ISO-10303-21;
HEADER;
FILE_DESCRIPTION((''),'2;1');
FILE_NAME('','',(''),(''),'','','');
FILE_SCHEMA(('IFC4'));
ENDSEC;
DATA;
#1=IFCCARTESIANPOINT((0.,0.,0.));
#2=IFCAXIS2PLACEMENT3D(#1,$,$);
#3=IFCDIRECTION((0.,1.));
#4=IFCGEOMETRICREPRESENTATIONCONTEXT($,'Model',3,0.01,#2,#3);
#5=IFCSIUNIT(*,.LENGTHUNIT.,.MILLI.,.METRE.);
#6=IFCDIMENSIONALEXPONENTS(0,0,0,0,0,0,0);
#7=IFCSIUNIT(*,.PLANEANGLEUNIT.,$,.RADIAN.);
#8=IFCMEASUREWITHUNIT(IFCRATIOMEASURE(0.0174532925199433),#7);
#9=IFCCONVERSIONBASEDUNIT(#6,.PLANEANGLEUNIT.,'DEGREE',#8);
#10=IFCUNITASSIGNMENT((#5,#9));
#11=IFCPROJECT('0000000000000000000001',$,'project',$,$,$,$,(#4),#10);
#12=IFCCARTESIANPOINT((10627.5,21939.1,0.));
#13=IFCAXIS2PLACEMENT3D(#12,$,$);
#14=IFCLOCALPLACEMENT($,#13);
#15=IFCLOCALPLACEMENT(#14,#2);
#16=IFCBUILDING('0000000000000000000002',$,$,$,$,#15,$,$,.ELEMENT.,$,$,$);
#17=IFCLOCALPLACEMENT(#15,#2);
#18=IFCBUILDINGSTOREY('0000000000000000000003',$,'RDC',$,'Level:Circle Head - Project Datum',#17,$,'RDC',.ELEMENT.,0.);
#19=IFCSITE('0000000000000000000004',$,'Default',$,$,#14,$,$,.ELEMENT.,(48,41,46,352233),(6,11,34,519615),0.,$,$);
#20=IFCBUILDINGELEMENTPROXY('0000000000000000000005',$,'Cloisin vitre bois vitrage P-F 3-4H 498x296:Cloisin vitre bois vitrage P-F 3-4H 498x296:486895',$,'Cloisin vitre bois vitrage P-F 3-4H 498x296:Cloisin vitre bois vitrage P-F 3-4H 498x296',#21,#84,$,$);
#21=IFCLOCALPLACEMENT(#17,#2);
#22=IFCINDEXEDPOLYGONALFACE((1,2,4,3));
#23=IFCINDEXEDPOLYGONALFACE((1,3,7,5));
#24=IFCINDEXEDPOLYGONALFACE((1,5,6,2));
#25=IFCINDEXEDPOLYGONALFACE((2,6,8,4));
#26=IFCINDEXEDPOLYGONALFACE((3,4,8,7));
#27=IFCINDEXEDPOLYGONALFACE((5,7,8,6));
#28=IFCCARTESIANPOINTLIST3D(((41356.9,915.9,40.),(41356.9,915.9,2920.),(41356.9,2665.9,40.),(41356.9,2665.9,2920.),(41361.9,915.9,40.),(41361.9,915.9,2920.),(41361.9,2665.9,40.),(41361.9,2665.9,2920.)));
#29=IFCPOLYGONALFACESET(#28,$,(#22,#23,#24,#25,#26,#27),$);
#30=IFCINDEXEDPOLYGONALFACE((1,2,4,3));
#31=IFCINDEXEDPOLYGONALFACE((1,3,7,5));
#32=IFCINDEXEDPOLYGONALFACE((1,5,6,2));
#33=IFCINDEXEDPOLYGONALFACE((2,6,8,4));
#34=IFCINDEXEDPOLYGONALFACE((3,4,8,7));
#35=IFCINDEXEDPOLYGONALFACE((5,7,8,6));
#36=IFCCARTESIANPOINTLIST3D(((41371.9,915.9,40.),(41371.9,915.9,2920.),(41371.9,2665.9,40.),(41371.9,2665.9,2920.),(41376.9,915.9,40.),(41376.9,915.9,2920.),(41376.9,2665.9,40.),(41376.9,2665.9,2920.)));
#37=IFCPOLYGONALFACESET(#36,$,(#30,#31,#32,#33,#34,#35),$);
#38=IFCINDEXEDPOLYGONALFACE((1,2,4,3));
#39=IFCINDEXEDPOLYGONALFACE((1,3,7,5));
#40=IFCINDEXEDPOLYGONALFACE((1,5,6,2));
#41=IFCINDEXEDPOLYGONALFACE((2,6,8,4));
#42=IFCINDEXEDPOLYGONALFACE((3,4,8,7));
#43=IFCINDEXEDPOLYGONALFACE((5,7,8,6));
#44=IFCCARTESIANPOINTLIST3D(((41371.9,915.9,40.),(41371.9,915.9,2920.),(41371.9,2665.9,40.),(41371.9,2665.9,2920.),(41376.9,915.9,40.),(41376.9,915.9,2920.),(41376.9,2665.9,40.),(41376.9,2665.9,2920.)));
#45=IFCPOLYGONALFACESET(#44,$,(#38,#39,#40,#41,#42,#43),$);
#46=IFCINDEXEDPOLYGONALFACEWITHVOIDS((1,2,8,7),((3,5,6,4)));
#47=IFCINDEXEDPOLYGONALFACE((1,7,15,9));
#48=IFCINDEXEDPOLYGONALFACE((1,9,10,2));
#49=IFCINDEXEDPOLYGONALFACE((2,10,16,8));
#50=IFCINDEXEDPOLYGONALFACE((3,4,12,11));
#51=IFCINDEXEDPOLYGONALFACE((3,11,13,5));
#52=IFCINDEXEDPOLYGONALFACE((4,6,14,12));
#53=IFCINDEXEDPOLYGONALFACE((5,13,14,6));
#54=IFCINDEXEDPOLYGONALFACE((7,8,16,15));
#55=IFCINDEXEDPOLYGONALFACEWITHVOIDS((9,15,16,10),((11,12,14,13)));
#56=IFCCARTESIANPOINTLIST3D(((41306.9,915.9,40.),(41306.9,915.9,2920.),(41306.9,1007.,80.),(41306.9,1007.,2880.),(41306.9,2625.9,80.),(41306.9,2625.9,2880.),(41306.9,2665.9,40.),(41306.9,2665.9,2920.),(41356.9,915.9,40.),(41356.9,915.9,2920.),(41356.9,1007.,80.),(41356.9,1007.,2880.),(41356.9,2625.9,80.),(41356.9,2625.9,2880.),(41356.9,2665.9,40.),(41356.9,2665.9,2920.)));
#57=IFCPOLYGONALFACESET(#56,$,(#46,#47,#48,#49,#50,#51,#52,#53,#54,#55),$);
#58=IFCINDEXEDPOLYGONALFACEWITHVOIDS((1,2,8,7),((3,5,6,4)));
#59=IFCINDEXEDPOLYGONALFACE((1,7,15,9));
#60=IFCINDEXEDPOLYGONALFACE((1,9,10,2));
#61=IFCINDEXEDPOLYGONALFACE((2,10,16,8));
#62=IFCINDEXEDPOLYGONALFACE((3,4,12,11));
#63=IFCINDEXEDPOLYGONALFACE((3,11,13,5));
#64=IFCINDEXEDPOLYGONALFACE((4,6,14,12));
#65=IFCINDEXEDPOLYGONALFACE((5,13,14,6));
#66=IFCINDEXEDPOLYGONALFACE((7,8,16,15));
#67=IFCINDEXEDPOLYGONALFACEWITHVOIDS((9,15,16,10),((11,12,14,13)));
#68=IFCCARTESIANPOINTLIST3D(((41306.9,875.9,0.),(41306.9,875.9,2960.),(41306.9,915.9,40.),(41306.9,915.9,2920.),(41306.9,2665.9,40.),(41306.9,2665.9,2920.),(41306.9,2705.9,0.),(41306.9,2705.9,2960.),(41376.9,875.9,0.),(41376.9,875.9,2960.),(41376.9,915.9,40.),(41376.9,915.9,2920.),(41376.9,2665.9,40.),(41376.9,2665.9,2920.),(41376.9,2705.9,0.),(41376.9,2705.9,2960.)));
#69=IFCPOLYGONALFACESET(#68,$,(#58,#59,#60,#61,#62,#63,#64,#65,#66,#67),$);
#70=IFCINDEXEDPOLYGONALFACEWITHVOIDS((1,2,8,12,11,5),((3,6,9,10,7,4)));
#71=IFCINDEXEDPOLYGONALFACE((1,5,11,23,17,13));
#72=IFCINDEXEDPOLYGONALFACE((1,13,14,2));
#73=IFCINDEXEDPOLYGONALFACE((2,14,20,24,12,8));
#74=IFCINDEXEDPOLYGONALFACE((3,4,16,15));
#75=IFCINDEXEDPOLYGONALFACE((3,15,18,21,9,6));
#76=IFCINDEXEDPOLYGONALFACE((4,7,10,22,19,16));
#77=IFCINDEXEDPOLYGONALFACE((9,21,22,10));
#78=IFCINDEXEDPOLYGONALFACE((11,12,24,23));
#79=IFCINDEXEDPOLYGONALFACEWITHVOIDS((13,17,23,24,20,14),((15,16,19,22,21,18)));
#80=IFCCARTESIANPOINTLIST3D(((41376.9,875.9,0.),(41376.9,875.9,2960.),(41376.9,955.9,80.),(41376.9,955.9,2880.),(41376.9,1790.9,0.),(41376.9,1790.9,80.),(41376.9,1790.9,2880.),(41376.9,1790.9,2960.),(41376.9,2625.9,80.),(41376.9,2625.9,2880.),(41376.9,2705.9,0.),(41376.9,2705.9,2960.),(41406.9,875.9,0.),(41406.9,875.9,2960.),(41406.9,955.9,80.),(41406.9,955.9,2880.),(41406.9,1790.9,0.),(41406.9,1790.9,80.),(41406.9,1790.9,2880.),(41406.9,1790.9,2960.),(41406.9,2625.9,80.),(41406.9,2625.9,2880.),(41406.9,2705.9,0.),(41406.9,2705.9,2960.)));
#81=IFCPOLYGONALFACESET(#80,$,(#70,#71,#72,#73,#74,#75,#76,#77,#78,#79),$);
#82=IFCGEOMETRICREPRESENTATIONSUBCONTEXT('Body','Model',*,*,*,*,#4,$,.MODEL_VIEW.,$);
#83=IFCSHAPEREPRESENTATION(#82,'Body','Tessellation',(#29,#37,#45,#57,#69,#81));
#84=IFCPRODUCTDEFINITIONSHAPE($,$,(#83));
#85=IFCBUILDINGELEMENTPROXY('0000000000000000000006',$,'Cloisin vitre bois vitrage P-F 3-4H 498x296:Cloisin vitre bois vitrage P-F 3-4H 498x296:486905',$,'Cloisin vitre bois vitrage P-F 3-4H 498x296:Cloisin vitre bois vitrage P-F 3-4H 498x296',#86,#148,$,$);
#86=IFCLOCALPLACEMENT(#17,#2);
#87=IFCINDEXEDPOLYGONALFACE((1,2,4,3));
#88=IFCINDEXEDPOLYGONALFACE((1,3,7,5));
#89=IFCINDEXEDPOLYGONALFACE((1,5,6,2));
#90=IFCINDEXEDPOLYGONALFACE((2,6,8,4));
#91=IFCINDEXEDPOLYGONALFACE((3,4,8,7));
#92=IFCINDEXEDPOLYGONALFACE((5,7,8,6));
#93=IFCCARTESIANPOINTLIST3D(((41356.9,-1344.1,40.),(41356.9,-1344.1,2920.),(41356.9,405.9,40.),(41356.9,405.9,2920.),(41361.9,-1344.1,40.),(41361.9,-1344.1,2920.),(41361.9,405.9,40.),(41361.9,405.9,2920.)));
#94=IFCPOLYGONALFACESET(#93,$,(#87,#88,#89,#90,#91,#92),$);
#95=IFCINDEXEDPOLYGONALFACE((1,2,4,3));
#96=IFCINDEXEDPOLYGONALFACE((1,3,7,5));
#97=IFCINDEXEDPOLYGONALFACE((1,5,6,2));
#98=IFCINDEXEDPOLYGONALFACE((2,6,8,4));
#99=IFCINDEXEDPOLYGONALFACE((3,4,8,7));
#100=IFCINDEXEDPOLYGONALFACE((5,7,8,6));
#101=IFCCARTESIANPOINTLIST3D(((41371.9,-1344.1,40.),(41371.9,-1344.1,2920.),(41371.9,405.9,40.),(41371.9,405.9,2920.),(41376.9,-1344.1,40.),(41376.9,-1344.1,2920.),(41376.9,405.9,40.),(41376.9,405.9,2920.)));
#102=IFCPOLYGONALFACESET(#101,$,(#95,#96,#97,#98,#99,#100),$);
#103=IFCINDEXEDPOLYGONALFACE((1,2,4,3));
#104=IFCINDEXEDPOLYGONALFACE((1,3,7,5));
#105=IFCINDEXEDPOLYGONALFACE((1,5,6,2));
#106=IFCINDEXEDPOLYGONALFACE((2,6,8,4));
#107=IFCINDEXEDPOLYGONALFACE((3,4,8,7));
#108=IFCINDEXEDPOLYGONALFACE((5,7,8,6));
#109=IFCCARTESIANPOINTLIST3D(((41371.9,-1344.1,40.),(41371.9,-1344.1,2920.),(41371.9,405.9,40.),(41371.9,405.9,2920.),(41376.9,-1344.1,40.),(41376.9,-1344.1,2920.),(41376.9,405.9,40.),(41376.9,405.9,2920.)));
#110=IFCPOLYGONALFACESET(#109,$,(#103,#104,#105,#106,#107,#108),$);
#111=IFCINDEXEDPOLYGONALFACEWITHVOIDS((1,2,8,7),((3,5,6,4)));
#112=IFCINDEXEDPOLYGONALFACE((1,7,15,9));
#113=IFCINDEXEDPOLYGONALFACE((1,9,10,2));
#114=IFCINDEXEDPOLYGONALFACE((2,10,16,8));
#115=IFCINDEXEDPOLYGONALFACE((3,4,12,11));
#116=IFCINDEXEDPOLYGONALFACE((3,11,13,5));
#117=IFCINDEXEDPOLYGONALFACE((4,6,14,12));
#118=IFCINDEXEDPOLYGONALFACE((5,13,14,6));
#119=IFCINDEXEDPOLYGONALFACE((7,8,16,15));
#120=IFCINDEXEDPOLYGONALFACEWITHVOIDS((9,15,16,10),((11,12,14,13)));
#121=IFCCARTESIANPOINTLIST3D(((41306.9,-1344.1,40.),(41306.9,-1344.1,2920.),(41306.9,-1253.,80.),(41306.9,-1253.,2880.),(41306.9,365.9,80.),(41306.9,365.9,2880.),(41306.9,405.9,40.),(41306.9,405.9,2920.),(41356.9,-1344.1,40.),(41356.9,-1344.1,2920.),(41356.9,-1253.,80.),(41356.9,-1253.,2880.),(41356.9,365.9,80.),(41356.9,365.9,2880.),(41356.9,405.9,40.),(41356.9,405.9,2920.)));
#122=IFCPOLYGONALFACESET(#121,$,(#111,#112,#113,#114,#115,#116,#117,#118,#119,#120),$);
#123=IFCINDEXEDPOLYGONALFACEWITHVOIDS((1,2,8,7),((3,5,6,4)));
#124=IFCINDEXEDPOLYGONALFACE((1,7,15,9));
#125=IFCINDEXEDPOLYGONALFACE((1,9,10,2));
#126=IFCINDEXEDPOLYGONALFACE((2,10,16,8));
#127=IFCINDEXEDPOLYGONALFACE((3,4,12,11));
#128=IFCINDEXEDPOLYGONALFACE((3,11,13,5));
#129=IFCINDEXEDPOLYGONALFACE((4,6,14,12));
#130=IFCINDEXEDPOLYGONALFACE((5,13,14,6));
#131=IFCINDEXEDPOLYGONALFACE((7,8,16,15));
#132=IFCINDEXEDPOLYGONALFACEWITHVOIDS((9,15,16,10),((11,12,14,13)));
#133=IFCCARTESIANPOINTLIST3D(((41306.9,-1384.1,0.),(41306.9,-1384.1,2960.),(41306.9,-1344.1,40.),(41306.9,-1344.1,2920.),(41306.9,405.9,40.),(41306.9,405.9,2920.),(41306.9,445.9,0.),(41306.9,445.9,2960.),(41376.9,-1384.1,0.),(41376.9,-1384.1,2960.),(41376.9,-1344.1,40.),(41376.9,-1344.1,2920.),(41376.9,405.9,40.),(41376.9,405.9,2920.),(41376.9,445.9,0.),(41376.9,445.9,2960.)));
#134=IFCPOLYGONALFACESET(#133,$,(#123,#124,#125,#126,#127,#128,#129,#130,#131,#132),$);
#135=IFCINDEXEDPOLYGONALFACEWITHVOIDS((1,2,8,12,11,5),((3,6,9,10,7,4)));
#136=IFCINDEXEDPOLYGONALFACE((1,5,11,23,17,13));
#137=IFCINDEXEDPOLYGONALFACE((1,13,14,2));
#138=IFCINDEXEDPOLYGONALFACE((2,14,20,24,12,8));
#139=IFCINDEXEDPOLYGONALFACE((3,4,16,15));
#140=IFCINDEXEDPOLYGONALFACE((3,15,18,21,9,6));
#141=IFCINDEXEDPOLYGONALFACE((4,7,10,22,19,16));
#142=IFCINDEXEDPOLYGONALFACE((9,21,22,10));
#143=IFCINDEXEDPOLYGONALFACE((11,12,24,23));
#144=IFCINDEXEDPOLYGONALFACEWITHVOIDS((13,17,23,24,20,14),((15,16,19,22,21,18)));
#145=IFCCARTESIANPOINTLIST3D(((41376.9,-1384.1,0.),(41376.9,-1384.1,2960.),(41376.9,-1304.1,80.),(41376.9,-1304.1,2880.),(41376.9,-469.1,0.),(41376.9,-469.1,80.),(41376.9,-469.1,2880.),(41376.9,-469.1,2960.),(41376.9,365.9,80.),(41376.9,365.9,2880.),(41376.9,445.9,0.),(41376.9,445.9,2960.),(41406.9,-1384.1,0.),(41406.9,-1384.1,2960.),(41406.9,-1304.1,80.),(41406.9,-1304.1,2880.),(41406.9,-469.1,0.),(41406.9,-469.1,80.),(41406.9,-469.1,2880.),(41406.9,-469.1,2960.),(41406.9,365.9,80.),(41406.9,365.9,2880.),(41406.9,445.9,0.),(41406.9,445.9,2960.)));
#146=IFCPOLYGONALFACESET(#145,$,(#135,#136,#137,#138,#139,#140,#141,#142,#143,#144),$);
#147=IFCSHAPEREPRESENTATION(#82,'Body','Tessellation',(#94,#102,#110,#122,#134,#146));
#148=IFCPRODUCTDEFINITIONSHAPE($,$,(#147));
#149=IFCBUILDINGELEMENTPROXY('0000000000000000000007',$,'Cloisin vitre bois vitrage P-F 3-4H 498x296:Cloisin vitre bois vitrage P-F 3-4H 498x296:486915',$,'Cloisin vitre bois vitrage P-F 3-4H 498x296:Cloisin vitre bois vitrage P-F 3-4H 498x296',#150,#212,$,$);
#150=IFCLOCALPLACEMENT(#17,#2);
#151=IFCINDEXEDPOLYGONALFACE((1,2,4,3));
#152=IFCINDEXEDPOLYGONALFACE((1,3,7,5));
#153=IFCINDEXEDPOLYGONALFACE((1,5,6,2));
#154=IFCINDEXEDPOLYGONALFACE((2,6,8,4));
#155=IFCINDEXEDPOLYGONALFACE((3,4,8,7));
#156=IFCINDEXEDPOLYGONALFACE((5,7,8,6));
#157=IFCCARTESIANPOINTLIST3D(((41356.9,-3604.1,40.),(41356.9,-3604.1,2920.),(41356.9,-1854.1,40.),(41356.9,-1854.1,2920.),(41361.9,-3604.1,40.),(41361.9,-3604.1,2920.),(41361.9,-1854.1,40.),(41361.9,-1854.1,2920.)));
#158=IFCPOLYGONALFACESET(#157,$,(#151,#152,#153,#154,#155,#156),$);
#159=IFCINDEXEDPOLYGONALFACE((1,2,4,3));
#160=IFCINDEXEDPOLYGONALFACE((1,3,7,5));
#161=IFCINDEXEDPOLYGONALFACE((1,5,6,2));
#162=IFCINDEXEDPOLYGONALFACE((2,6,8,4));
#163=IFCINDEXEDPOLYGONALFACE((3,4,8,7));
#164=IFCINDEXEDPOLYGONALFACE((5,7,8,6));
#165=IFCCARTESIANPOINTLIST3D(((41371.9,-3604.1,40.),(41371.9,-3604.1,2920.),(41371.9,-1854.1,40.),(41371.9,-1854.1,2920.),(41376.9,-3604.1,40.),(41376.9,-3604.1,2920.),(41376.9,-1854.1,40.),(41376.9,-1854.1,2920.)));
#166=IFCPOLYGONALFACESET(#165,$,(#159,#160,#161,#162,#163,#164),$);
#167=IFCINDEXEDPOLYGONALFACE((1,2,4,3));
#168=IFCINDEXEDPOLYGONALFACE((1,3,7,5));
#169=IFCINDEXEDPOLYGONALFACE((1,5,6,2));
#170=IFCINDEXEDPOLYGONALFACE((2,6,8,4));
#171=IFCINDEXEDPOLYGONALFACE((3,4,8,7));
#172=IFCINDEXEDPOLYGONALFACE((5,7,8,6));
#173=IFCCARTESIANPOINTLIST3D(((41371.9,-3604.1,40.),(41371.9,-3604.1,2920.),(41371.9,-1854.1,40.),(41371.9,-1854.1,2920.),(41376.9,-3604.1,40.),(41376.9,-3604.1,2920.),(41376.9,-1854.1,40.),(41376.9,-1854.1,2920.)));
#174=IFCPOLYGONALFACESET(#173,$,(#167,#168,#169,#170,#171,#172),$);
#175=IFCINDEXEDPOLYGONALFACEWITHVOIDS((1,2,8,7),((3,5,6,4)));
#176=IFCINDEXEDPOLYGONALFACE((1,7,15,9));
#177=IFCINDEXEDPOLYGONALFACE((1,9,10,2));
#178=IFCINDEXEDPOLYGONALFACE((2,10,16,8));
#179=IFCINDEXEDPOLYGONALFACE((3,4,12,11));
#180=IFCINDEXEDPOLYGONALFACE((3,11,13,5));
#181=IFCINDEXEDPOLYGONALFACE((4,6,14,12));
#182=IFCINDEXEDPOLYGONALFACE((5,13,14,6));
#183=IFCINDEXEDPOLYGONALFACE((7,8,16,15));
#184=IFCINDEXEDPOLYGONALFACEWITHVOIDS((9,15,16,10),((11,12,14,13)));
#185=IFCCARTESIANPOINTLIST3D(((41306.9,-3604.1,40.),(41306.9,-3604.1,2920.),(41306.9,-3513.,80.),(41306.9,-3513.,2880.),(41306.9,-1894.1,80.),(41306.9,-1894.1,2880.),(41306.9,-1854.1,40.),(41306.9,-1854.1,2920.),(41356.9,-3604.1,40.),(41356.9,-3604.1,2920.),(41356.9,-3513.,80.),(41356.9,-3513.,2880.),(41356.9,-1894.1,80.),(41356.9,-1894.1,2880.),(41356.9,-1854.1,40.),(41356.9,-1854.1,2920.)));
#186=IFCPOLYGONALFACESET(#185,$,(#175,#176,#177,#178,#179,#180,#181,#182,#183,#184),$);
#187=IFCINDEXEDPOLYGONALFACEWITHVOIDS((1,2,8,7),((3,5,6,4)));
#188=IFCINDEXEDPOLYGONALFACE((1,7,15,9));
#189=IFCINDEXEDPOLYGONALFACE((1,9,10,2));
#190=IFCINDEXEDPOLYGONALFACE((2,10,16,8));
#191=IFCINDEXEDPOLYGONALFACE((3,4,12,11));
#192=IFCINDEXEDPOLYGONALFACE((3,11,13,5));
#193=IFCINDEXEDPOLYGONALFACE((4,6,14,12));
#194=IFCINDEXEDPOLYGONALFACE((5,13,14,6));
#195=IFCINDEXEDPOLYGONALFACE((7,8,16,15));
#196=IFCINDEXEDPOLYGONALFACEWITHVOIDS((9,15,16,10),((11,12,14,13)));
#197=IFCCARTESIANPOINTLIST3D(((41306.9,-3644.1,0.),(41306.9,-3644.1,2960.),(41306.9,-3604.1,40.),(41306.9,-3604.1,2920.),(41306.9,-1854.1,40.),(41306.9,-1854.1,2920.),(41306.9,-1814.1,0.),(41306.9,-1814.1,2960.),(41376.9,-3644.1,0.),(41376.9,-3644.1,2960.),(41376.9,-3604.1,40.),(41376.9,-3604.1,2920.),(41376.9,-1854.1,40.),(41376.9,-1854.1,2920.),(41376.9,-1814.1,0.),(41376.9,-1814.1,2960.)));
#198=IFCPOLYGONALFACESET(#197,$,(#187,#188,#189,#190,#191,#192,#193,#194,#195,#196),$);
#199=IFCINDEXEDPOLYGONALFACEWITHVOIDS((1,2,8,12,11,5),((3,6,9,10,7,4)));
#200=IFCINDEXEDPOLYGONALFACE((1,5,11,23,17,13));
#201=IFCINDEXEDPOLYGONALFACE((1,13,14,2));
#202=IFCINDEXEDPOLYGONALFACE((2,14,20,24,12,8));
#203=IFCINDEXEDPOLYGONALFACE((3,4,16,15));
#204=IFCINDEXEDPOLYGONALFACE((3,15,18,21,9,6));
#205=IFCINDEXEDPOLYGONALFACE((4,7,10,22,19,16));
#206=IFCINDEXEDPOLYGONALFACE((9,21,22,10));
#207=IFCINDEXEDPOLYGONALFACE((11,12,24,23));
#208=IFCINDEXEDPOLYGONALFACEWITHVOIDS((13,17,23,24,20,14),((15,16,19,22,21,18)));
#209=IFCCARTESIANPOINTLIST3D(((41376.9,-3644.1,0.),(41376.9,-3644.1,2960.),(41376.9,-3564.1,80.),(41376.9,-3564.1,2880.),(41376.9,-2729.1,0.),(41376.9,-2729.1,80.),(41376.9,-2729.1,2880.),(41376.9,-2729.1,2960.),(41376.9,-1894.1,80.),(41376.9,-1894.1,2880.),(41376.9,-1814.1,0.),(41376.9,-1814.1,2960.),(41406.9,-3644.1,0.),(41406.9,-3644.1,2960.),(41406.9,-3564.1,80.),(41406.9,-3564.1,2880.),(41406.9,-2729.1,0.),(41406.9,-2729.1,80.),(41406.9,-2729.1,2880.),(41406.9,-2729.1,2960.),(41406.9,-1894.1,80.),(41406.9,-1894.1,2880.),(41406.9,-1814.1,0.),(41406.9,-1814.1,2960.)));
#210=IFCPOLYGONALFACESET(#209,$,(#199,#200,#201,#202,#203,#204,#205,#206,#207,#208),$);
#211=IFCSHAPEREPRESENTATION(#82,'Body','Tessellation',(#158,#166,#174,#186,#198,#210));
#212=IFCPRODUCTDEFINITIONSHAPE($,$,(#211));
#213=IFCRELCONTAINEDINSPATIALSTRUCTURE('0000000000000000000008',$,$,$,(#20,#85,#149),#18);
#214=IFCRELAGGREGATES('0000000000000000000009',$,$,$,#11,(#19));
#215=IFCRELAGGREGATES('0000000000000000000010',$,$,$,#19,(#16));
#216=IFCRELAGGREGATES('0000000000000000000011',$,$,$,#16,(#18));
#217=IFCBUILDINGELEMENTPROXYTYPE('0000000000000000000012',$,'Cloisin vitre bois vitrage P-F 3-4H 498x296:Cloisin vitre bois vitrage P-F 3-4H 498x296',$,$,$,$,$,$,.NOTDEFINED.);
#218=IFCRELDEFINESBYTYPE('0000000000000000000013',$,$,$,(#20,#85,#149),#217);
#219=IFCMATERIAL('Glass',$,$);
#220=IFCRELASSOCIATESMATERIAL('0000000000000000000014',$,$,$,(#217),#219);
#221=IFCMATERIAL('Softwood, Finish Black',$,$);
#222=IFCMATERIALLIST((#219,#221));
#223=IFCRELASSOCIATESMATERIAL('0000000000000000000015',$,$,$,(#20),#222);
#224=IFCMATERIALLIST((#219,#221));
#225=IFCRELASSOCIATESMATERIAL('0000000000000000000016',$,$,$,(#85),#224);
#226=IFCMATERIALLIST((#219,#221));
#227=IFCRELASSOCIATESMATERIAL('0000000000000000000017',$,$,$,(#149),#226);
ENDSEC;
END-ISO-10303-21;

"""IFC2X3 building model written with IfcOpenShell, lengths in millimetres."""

from ifc_helpers import new_model, entity, si_unit, converted_unit, direction, frame, frame_2d, origin, place, context, subcontext, project, spatial, polyline, rectangle, outline, extrude, source, transform, mapped, material, material_list, type_object, type_shapes, element, save


model = new_model("IFC2X3")

# Units and contexts
model_context = context("Model", 3, precision=0.01, world=origin(), true_north=direction((0.0, 1.0)))
body_context = subcontext(model_context, "Body", "Model", "MODEL_VIEW")
ifc_project = project(units=[si_unit("LENGTHUNIT", "METRE", prefix="MILLI"), converted_unit("PLANEANGLEUNIT", "DEGREE", entity("IfcRatioMeasure", 0.0174532925199433), si_unit("PLANEANGLEUNIT", "RADIAN"), dimensions=[0, 0, 0, 0, 0, 0, 0])], contexts=[model_context])

# Site, building, storey
site_placement = place(None, frame((10627.5, 21939.1, 0.0)))
site = spatial("IfcSite", under=ifc_project, at=site_placement, Name="Default", CompositionType="ELEMENT", RefLatitude=(48, 41, 46, 352233), RefLongitude=(6, 11, 34, 519615), RefElevation=0.0)
building_placement = place(site_placement, origin())
building = spatial("IfcBuilding", under=site, at=building_placement, CompositionType="ELEMENT")
storey_placement = place(building_placement, origin())
storey = spatial("IfcBuildingStorey", under=building, at=storey_placement, Name="RDC", ObjectType="Level:Circle Head - Project Datum", LongName="RDC", CompositionType="ELEMENT", Elevation=0.0)

# Building element proxies
ifc_material_1 = material(Name="Glass")
ifc_material_2 = material(Name="Softwood, Finish Black")
ifc_material_list_1 = material_list([ifc_material_1, ifc_material_2])
building_element_proxy_type_1 = type_object("IfcBuildingElementProxyType", Name="Cloisin vitre bois vitrage P-F 3-4H 498x296:Cloisin vitre bois vitrage P-F 3-4H 498x296", PredefinedType="NOTDEFINED", material=ifc_material_1)
shared_shape_1 = source(origin(), body_context, "Body", "SweptSolid", [
    extrude(rectangle(XDim=5.0, YDim=1750.0, at=frame_2d((0.0, 0.0), x_axis=(1.0, 0.0))), frame((0.0, -47.5, 40.0), z_axis=(0.0, 0.0, 1.0), x_axis=(0.0, 1.0, 0.0)), (0.0, 0.0, 1.0), 2880.0),
    extrude(rectangle(XDim=5.0, YDim=1750.0, at=frame_2d((0.0, 0.0), x_axis=(1.0, 0.0))), frame((0.0, -32.5, 40.0), z_axis=(0.0, 0.0, 1.0), x_axis=(0.0, 1.0, 0.0)), (0.0, 0.0, 1.0), 2880.0),
    extrude(rectangle(XDim=5.0, YDim=1750.0, at=frame_2d((0.0, 0.0), x_axis=(1.0, 0.0))), frame((0.0, -32.5, 40.0), z_axis=(0.0, 0.0, 1.0), x_axis=(0.0, 1.0, 0.0)), (0.0, 0.0, 1.0), 2880.0),
    extrude(outline(polyline([(-1440.0, -875.0), (1440.0, -875.0), (1440.0, 875.0), (-1440.0, 875.0), (-1440.0, -875.0)]), holes=[polyline([(1400.0, 835.0), (1400.0, -783.9), (-1400.0, -783.9), (-1400.0, 835.0), (1400.0, 835.0)])]), frame((0.0, -100.0, 1480.0), z_axis=(0.0, 1.0, 0.0), x_axis=(0.0, 0.0, -1.0)), (0.0, 0.0, 1.0), 50.0),
    extrude(outline(polyline([(-1480.0, -915.0), (1480.0, -915.0), (1480.0, 915.0), (-1480.0, 915.0), (-1480.0, -915.0)]), holes=[polyline([(-1440.0, -875.0), (-1440.0, 875.0), (1440.0, 875.0), (1440.0, -875.0), (-1440.0, -875.0)])]), frame((0.0, -100.0, 1480.0), z_axis=(0.0, 1.0, 0.0), x_axis=(0.0, 0.0, -1.0)), (0.0, 0.0, 1.0), 70.0),
    extrude(outline(polyline([(-1480.0, -915.0), (1480.0, -915.0), (1480.0, 0.0), (1480.0, 915.0), (-1480.0, 915.0), (-1480.0, 0.0), (-1480.0, -915.0)]), holes=[polyline([(1400.0, 0.0), (1400.0, -835.0), (-1400.0, -835.0), (-1400.0, 0.0), (-1400.0, 835.0), (1400.0, 835.0), (1400.0, 0.0)])]), frame((0.0, -30.0, 1480.0), z_axis=(0.0, 1.0, 0.0), x_axis=(0.0, 0.0, 1.0)), (0.0, 0.0, 1.0), 30.0),
])
type_shapes(building_element_proxy_type_1, [shared_shape_1])
proxy_1_placement = place(storey_placement, frame((41406.9, 1790.9, 0.0), z_axis=(0.0, 0.0, 1.0), x_axis=(0.0, -1.0, 0.0)))
element("IfcBuildingElementProxy", 1, at=proxy_1_placement, inside=storey, type_object=building_element_proxy_type_1, material=ifc_material_list_1, Name="Cloisin vitre bois vitrage P-F 3-4H 498x296:Cloisin vitre bois vitrage P-F 3-4H 498x296:486895", ObjectType="Cloisin vitre bois vitrage P-F 3-4H 498x296:Cloisin vitre bois vitrage P-F 3-4H 498x296", context=body_context, shape_type="MappedRepresentation", body=[
    mapped(shared_shape_1, transform((0.0, 0.0, 0.0), scale=1.0)),
])
ifc_material_list_2 = material_list([ifc_material_1, ifc_material_2])
proxy_2_placement = place(storey_placement, frame((41406.9, -469.1, 0.0), z_axis=(0.0, 0.0, 1.0), x_axis=(0.0, -1.0, 0.0)))
element("IfcBuildingElementProxy", 2, at=proxy_2_placement, inside=storey, type_object=building_element_proxy_type_1, material=ifc_material_list_2, Name="Cloisin vitre bois vitrage P-F 3-4H 498x296:Cloisin vitre bois vitrage P-F 3-4H 498x296:486905", ObjectType="Cloisin vitre bois vitrage P-F 3-4H 498x296:Cloisin vitre bois vitrage P-F 3-4H 498x296", context=body_context, shape_type="MappedRepresentation", body=[
    mapped(shared_shape_1, transform((0.0, 0.0, 0.0), scale=1.0)),
])
ifc_material_list_3 = material_list([ifc_material_1, ifc_material_2])
proxy_3_placement = place(storey_placement, frame((41406.9, -2729.1, 0.0), z_axis=(0.0, 0.0, 1.0), x_axis=(0.0, -1.0, 0.0)))
element("IfcBuildingElementProxy", 3, at=proxy_3_placement, inside=storey, type_object=building_element_proxy_type_1, material=ifc_material_list_3, Name="Cloisin vitre bois vitrage P-F 3-4H 498x296:Cloisin vitre bois vitrage P-F 3-4H 498x296:486915", ObjectType="Cloisin vitre bois vitrage P-F 3-4H 498x296:Cloisin vitre bois vitrage P-F 3-4H 498x296", context=body_context, shape_type="MappedRepresentation", body=[
    mapped(shared_shape_1, transform((0.0, 0.0, 0.0), scale=1.0)),
])

save(model, "model.ifc")
